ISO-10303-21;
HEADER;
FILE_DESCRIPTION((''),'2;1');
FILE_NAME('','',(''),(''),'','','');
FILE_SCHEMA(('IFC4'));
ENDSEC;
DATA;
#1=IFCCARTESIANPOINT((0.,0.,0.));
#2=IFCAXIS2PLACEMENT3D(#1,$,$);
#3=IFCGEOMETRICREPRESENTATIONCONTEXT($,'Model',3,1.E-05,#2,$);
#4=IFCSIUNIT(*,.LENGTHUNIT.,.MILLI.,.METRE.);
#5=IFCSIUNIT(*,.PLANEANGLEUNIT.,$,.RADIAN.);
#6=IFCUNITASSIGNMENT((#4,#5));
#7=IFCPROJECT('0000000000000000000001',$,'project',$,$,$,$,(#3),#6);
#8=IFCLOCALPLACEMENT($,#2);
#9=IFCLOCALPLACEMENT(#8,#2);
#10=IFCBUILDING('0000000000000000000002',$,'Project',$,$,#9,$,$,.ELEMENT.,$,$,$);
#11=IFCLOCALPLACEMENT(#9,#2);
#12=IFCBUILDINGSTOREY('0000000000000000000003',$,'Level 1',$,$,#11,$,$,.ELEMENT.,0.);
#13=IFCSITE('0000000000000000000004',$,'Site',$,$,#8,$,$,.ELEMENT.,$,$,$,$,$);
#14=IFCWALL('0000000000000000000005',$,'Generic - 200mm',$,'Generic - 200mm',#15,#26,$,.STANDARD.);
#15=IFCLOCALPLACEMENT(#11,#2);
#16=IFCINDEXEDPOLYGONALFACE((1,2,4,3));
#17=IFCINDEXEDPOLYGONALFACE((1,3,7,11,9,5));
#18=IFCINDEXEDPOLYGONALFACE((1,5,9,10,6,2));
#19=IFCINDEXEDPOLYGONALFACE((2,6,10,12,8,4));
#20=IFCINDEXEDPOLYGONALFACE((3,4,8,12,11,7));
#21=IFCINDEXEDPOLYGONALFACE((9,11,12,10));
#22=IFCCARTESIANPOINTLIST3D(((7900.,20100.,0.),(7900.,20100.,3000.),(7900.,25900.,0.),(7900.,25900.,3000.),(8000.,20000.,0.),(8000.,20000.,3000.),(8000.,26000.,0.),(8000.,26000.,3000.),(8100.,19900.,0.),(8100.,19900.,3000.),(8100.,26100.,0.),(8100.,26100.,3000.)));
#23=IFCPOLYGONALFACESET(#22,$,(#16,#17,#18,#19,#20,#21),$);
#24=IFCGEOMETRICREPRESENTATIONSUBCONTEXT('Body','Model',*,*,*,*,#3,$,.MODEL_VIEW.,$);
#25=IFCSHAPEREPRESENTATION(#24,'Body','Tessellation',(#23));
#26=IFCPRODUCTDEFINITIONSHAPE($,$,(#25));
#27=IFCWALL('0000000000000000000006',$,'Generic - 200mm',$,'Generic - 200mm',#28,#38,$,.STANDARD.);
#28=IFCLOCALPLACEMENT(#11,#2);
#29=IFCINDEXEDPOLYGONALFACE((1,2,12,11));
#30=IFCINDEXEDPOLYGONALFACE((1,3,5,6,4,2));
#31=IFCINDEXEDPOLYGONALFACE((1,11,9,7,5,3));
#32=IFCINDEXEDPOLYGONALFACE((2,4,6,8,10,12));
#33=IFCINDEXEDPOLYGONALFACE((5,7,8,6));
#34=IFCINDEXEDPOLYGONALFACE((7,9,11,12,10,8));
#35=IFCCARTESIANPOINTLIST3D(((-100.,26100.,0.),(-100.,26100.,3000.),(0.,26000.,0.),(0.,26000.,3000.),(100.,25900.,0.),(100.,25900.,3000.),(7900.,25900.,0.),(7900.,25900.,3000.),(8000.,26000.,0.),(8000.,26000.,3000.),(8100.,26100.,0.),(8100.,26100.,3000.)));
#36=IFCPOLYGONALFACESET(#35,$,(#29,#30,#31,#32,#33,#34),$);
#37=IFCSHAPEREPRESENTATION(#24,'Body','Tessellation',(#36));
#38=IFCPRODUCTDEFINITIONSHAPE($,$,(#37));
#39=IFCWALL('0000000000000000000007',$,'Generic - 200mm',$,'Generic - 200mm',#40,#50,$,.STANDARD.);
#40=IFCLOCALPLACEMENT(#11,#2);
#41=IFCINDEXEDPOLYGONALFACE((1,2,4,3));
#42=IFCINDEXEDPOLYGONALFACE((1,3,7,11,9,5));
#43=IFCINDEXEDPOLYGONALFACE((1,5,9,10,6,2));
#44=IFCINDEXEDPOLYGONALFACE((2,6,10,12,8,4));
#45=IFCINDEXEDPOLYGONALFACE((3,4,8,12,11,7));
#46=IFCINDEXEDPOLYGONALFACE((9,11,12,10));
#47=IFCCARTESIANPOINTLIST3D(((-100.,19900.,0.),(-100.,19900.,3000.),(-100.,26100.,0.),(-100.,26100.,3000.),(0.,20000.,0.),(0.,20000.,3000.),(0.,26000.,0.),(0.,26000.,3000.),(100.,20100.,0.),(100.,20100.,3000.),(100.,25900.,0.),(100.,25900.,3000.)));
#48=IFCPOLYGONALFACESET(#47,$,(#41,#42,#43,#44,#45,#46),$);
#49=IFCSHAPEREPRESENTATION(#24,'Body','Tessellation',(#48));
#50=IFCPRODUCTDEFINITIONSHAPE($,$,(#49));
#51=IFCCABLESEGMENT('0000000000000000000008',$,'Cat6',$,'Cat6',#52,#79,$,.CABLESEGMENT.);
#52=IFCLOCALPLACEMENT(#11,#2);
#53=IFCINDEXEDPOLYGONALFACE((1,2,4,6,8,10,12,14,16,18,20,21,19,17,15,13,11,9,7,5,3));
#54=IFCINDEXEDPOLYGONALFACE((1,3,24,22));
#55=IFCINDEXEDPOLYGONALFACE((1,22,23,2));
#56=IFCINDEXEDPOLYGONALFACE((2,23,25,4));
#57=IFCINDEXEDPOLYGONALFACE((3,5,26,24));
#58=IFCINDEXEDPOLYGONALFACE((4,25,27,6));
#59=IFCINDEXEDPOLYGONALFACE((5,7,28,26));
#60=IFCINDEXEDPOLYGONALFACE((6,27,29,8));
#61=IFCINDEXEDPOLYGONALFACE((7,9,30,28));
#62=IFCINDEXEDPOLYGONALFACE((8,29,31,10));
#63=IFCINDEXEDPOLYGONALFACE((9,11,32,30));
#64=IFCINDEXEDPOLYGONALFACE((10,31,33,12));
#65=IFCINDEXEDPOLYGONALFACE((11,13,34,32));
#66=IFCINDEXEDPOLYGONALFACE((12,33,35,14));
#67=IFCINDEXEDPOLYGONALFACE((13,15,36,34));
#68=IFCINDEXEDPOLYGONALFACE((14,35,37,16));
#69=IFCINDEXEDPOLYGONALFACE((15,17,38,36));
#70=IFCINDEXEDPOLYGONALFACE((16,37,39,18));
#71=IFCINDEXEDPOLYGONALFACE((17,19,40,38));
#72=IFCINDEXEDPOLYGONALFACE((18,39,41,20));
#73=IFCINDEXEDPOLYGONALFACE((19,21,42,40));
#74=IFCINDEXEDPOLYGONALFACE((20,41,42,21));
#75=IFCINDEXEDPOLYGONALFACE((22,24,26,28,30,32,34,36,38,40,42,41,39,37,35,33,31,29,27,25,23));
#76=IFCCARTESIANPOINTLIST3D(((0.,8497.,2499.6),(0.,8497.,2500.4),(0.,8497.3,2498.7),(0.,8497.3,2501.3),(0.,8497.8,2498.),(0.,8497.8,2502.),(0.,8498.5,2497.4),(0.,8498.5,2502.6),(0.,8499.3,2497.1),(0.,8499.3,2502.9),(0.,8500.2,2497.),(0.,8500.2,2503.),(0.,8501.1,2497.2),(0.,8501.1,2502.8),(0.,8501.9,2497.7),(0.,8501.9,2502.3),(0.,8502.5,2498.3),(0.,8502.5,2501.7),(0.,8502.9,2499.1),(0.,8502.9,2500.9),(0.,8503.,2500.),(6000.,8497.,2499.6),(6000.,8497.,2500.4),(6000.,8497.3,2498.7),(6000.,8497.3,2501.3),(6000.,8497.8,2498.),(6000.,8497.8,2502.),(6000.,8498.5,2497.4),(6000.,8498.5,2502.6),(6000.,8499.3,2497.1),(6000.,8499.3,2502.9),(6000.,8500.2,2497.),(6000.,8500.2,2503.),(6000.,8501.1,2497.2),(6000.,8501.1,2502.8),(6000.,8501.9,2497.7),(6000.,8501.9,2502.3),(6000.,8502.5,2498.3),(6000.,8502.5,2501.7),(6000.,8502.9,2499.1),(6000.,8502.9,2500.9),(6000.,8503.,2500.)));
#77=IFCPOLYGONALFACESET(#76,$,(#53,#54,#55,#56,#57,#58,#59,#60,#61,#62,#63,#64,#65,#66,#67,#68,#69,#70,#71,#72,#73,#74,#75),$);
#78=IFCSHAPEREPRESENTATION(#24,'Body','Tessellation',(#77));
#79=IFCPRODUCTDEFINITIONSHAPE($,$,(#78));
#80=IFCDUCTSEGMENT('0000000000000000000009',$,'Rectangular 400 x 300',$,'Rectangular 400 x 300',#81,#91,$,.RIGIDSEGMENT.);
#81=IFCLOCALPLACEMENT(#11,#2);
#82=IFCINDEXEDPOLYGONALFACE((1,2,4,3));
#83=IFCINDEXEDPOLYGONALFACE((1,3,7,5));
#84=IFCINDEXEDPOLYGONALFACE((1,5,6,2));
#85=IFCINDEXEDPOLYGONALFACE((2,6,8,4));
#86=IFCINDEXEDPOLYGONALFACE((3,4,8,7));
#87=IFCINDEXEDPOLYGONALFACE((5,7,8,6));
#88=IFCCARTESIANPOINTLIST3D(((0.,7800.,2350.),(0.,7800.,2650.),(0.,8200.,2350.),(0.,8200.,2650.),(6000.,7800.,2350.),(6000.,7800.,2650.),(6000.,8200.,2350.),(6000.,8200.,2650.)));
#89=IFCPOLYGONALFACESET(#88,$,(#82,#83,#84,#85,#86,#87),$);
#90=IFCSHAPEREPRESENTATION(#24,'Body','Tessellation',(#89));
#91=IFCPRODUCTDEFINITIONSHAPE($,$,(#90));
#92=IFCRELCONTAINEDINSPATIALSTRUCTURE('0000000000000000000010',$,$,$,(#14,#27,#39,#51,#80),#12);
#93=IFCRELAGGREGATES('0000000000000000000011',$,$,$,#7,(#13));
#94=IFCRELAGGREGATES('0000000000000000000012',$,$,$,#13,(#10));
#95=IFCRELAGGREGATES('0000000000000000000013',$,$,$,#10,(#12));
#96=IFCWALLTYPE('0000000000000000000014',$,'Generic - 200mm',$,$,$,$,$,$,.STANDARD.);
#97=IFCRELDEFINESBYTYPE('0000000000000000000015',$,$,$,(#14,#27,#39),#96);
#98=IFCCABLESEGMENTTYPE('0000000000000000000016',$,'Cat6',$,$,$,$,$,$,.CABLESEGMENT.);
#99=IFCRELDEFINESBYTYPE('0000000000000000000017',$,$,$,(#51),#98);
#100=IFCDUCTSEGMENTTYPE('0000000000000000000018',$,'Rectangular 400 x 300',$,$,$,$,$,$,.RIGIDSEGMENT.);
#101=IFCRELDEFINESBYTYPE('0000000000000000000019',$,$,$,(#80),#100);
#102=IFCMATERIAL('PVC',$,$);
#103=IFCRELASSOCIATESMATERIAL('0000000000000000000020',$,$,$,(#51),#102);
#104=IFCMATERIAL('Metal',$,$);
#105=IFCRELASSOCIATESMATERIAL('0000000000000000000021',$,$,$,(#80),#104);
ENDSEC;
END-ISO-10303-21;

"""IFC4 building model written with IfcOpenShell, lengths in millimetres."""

from ifc_helpers import new_model, si_unit, frame, origin, origin_2d, place, context, subcontext, project, spatial, polyline, rectangle, circle, outline, extrude, material, type_object, element, save


model = new_model("IFC4")

# Units and contexts
model_context = context("Model", 3, precision=1e-05, world=origin())
body_context = subcontext(model_context, "Body", "Model", "MODEL_VIEW")
ifc_project = project(units=[si_unit("LENGTHUNIT", "METRE", prefix="MILLI"), si_unit("PLANEANGLEUNIT", "RADIAN")], contexts=[model_context])

# Site, building, storey
site_placement = place(None, origin())
site = spatial("IfcSite", under=ifc_project, at=site_placement, Name="Site", CompositionType="ELEMENT")
building_placement = place(site_placement, origin())
building = spatial("IfcBuilding", under=site, at=building_placement, Name="Project", CompositionType="ELEMENT")
storey_placement = place(building_placement, origin())
storey = spatial("IfcBuildingStorey", under=building, at=storey_placement, Name="Level 1", CompositionType="ELEMENT", Elevation=0.0)

# Shared definitions
ifc_material_1 = material(Name="Metal")

# Walls
wall_type = type_object("IfcWallType", Name="Generic - 200mm", PredefinedType="STANDARD")
wall_1_placement = place(storey_placement, frame((8000.0, 20000.0, 0.0), z_axis=(0.0, 0.0, 1.0), x_axis=(0.0, 1.0, 0.0)))
element("IfcWall", 1, at=wall_1_placement, inside=storey, type_object=wall_type, Name="Generic - 200mm", ObjectType="Generic - 200mm", PredefinedType="STANDARD", context=body_context, shape_type="SweptSolid", body=[
    extrude(outline(polyline([(-100.0, -100.0), (0.0, 0.0), (100.0, 100.0), (5900.0, 100.0), (6000.0, 0.0), (6100.0, -100.0), (-100.0, -100.0)])), origin(), (0.0, 0.0, 1.0), 3000.0),
])
wall_2_placement = place(storey_placement, frame((8000.0, 26000.0, 0.0), z_axis=(0.0, 0.0, 1.0), x_axis=(-1.0, 0.0, 0.0)))
element("IfcWall", 2, at=wall_2_placement, inside=storey, type_object=wall_type, Name="Generic - 200mm", ObjectType="Generic - 200mm", PredefinedType="STANDARD", context=body_context, shape_type="SweptSolid", body=[
    extrude(outline(polyline([(-100.0, -100.0), (0.0, 0.0), (100.0, 100.0), (7900.0, 100.0), (8000.0, 0.0), (8100.0, -100.0), (-100.0, -100.0)])), origin(), (0.0, 0.0, 1.0), 3000.0),
])
wall_3_placement = place(storey_placement, frame((0.0, 26000.0, 0.0), z_axis=(0.0, 0.0, 1.0), x_axis=(0.0, -1.0, 0.0)))
element("IfcWall", 3, at=wall_3_placement, inside=storey, type_object=wall_type, Name="Generic - 200mm", ObjectType="Generic - 200mm", PredefinedType="STANDARD", context=body_context, shape_type="SweptSolid", body=[
    extrude(outline(polyline([(-100.0, -100.0), (0.0, 0.0), (100.0, 100.0), (5900.0, 100.0), (6000.0, 0.0), (6100.0, -100.0), (-100.0, -100.0)])), origin(), (0.0, 0.0, 1.0), 3000.0),
])

# Cable segment
ifc_material_2 = material(Name="PVC")
cable_segment_type = type_object("IfcCableSegmentType", Name="Cat6", PredefinedType="CABLESEGMENT")
cable_segment_placement = place(storey_placement, frame((0.0, 8500.0, 2500.0)))
element("IfcCableSegment", 4, at=cable_segment_placement, inside=storey, type_object=cable_segment_type, material=ifc_material_2, Name="Cat6", ObjectType="Cat6", PredefinedType="CABLESEGMENT", context=body_context, shape_type="SweptSolid", body=[
    extrude(circle(Radius=3.0, at=origin_2d()), frame((0.0, 0.0, 0.0), z_axis=(1.0, 0.0, 0.0), x_axis=(0.0, 1.0, 0.0)), (0.0, 0.0, 1.0), 6000.0),
])

# Duct segment
duct_segment_type = type_object("IfcDuctSegmentType", Name="Rectangular 400 x 300", PredefinedType="RIGIDSEGMENT")
duct_segment_placement = place(storey_placement, frame((0.0, 8000.0, 2500.0)))
element("IfcDuctSegment", 5, at=duct_segment_placement, inside=storey, type_object=duct_segment_type, material=ifc_material_1, Name="Rectangular 400 x 300", ObjectType="Rectangular 400 x 300", PredefinedType="RIGIDSEGMENT", context=body_context, shape_type="SweptSolid", body=[
    extrude(rectangle(XDim=400.0, YDim=300.0, at=origin_2d()), frame((0.0, 0.0, 0.0), z_axis=(1.0, 0.0, 0.0), x_axis=(0.0, 1.0, 0.0)), (0.0, 0.0, 1.0), 6000.0),
])

save(model, "model.ifc")
